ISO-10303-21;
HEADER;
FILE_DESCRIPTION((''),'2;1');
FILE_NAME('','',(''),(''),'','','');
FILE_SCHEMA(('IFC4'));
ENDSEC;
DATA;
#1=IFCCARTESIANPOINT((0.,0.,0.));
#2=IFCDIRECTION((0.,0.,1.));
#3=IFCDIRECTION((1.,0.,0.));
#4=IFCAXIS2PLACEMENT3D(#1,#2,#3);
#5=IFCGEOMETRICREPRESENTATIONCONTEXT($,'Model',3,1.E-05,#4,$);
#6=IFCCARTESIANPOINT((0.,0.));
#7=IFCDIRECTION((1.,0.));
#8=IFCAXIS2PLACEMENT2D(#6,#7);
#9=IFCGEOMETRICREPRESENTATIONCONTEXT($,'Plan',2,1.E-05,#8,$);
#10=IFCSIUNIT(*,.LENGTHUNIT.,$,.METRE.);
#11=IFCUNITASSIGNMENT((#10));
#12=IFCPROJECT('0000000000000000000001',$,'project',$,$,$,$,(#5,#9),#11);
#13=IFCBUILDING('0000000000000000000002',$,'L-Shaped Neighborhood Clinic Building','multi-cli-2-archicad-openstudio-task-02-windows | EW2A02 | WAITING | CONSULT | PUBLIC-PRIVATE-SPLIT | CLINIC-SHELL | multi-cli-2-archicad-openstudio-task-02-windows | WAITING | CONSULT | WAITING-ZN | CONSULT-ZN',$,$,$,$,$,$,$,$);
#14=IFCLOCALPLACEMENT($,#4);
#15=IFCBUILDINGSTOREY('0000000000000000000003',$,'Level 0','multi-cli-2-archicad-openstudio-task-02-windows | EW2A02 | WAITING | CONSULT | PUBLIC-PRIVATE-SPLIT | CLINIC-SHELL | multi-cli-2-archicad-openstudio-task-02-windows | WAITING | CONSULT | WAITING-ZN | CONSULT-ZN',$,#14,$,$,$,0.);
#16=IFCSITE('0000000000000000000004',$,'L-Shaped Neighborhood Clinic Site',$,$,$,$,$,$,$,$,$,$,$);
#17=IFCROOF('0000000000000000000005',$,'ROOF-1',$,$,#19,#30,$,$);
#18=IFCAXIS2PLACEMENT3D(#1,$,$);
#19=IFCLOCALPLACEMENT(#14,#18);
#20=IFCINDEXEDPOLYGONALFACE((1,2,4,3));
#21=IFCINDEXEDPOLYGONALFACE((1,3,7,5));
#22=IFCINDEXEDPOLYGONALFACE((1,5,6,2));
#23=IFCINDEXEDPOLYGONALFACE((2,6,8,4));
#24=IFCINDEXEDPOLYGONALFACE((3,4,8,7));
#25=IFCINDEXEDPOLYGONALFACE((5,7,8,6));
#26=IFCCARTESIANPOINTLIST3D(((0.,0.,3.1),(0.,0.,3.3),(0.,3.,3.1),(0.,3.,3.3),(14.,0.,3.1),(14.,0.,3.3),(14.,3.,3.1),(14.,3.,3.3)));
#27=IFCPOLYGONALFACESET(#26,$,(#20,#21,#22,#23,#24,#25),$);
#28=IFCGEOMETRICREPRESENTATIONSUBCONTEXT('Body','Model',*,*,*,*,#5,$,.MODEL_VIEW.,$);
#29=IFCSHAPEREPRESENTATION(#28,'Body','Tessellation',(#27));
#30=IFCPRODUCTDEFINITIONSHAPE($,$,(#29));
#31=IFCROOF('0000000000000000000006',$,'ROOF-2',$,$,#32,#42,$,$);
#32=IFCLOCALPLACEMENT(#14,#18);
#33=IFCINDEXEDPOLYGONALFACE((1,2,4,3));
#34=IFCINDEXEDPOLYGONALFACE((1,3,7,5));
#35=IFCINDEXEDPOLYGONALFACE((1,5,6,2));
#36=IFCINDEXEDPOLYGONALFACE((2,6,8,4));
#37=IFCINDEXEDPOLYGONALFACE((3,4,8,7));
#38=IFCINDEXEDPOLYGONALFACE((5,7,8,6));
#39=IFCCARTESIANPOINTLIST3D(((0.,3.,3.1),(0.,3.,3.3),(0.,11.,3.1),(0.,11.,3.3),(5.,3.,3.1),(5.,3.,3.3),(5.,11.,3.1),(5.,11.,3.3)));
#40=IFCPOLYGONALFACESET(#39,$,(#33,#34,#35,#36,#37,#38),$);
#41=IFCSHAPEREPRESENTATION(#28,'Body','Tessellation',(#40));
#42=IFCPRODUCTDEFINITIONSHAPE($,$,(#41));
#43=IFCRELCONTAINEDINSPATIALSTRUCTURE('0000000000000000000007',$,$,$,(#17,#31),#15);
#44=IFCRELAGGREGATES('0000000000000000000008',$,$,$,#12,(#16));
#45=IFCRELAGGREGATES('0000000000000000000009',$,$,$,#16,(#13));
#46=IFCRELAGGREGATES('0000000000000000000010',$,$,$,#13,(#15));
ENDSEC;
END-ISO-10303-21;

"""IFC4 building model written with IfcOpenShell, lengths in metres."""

from ifc_helpers import new_model, si_unit, frame, origin_with_axes, origin_2d_with_axis, place, context, subcontext, project, spatial, indexed_curve, outline, extrude, element, save


model = new_model("IFC4")

# Units and contexts
model_context = context("Model", 3, precision=1e-05, world=origin_with_axes())
plan_context = context("Plan", 2, precision=1e-05, world=origin_2d_with_axis())
body_context = subcontext(model_context, "Body", "Model", "MODEL_VIEW")
ifc_project = project(units=[si_unit("LENGTHUNIT", "METRE")], contexts=[model_context, plan_context])

# Site, building, storey
site = spatial("IfcSite", under=ifc_project, Name="L-Shaped Neighborhood Clinic Site")
building = spatial("IfcBuilding", under=site, Name="L-Shaped Neighborhood Clinic Building", Description="multi-cli-2-archicad-openstudio-task-02-windows | EW2A02 | WAITING | CONSULT | PUBLIC-PRIVATE-SPLIT | CLINIC-SHELL | multi-cli-2-archicad-openstudio-task-02-windows | WAITING | CONSULT | WAITING-ZN | CONSULT-ZN")
storey_placement = place(None, origin_with_axes())
storey = spatial("IfcBuildingStorey", under=building, at=storey_placement, Name="Level 0", Description="multi-cli-2-archicad-openstudio-task-02-windows | EW2A02 | WAITING | CONSULT | PUBLIC-PRIVATE-SPLIT | CLINIC-SHELL | multi-cli-2-archicad-openstudio-task-02-windows | WAITING | CONSULT | WAITING-ZN | CONSULT-ZN", Elevation=0.0)

# Roofs
roof_1_placement = place(storey_placement, frame((0.0, 0.0, 3.1), z_axis=(0.0, 0.0, 1.0), x_axis=(1.0, 0.0, 0.0)))
element("IfcRoof", 1, at=roof_1_placement, inside=storey, Name="ROOF-1", context=body_context, shape_type="SweptSolid", body=[
    extrude(outline(indexed_curve([(0.0, 0.0), (14.0, 0.0), (14.0, 3.0), (0.0, 3.0)])), None, (0.0, 0.0, 1.0), 0.2),
])
roof_2_placement = place(storey_placement, frame((0.0, 0.0, 3.1), z_axis=(0.0, 0.0, 1.0), x_axis=(1.0, 0.0, 0.0)))
element("IfcRoof", 2, at=roof_2_placement, inside=storey, Name="ROOF-2", context=body_context, shape_type="SweptSolid", body=[
    extrude(outline(indexed_curve([(0.0, 3.0), (5.0, 3.0), (5.0, 11.0), (0.0, 11.0)])), None, (0.0, 0.0, 1.0), 0.2),
])

save(model, "model.ifc")
